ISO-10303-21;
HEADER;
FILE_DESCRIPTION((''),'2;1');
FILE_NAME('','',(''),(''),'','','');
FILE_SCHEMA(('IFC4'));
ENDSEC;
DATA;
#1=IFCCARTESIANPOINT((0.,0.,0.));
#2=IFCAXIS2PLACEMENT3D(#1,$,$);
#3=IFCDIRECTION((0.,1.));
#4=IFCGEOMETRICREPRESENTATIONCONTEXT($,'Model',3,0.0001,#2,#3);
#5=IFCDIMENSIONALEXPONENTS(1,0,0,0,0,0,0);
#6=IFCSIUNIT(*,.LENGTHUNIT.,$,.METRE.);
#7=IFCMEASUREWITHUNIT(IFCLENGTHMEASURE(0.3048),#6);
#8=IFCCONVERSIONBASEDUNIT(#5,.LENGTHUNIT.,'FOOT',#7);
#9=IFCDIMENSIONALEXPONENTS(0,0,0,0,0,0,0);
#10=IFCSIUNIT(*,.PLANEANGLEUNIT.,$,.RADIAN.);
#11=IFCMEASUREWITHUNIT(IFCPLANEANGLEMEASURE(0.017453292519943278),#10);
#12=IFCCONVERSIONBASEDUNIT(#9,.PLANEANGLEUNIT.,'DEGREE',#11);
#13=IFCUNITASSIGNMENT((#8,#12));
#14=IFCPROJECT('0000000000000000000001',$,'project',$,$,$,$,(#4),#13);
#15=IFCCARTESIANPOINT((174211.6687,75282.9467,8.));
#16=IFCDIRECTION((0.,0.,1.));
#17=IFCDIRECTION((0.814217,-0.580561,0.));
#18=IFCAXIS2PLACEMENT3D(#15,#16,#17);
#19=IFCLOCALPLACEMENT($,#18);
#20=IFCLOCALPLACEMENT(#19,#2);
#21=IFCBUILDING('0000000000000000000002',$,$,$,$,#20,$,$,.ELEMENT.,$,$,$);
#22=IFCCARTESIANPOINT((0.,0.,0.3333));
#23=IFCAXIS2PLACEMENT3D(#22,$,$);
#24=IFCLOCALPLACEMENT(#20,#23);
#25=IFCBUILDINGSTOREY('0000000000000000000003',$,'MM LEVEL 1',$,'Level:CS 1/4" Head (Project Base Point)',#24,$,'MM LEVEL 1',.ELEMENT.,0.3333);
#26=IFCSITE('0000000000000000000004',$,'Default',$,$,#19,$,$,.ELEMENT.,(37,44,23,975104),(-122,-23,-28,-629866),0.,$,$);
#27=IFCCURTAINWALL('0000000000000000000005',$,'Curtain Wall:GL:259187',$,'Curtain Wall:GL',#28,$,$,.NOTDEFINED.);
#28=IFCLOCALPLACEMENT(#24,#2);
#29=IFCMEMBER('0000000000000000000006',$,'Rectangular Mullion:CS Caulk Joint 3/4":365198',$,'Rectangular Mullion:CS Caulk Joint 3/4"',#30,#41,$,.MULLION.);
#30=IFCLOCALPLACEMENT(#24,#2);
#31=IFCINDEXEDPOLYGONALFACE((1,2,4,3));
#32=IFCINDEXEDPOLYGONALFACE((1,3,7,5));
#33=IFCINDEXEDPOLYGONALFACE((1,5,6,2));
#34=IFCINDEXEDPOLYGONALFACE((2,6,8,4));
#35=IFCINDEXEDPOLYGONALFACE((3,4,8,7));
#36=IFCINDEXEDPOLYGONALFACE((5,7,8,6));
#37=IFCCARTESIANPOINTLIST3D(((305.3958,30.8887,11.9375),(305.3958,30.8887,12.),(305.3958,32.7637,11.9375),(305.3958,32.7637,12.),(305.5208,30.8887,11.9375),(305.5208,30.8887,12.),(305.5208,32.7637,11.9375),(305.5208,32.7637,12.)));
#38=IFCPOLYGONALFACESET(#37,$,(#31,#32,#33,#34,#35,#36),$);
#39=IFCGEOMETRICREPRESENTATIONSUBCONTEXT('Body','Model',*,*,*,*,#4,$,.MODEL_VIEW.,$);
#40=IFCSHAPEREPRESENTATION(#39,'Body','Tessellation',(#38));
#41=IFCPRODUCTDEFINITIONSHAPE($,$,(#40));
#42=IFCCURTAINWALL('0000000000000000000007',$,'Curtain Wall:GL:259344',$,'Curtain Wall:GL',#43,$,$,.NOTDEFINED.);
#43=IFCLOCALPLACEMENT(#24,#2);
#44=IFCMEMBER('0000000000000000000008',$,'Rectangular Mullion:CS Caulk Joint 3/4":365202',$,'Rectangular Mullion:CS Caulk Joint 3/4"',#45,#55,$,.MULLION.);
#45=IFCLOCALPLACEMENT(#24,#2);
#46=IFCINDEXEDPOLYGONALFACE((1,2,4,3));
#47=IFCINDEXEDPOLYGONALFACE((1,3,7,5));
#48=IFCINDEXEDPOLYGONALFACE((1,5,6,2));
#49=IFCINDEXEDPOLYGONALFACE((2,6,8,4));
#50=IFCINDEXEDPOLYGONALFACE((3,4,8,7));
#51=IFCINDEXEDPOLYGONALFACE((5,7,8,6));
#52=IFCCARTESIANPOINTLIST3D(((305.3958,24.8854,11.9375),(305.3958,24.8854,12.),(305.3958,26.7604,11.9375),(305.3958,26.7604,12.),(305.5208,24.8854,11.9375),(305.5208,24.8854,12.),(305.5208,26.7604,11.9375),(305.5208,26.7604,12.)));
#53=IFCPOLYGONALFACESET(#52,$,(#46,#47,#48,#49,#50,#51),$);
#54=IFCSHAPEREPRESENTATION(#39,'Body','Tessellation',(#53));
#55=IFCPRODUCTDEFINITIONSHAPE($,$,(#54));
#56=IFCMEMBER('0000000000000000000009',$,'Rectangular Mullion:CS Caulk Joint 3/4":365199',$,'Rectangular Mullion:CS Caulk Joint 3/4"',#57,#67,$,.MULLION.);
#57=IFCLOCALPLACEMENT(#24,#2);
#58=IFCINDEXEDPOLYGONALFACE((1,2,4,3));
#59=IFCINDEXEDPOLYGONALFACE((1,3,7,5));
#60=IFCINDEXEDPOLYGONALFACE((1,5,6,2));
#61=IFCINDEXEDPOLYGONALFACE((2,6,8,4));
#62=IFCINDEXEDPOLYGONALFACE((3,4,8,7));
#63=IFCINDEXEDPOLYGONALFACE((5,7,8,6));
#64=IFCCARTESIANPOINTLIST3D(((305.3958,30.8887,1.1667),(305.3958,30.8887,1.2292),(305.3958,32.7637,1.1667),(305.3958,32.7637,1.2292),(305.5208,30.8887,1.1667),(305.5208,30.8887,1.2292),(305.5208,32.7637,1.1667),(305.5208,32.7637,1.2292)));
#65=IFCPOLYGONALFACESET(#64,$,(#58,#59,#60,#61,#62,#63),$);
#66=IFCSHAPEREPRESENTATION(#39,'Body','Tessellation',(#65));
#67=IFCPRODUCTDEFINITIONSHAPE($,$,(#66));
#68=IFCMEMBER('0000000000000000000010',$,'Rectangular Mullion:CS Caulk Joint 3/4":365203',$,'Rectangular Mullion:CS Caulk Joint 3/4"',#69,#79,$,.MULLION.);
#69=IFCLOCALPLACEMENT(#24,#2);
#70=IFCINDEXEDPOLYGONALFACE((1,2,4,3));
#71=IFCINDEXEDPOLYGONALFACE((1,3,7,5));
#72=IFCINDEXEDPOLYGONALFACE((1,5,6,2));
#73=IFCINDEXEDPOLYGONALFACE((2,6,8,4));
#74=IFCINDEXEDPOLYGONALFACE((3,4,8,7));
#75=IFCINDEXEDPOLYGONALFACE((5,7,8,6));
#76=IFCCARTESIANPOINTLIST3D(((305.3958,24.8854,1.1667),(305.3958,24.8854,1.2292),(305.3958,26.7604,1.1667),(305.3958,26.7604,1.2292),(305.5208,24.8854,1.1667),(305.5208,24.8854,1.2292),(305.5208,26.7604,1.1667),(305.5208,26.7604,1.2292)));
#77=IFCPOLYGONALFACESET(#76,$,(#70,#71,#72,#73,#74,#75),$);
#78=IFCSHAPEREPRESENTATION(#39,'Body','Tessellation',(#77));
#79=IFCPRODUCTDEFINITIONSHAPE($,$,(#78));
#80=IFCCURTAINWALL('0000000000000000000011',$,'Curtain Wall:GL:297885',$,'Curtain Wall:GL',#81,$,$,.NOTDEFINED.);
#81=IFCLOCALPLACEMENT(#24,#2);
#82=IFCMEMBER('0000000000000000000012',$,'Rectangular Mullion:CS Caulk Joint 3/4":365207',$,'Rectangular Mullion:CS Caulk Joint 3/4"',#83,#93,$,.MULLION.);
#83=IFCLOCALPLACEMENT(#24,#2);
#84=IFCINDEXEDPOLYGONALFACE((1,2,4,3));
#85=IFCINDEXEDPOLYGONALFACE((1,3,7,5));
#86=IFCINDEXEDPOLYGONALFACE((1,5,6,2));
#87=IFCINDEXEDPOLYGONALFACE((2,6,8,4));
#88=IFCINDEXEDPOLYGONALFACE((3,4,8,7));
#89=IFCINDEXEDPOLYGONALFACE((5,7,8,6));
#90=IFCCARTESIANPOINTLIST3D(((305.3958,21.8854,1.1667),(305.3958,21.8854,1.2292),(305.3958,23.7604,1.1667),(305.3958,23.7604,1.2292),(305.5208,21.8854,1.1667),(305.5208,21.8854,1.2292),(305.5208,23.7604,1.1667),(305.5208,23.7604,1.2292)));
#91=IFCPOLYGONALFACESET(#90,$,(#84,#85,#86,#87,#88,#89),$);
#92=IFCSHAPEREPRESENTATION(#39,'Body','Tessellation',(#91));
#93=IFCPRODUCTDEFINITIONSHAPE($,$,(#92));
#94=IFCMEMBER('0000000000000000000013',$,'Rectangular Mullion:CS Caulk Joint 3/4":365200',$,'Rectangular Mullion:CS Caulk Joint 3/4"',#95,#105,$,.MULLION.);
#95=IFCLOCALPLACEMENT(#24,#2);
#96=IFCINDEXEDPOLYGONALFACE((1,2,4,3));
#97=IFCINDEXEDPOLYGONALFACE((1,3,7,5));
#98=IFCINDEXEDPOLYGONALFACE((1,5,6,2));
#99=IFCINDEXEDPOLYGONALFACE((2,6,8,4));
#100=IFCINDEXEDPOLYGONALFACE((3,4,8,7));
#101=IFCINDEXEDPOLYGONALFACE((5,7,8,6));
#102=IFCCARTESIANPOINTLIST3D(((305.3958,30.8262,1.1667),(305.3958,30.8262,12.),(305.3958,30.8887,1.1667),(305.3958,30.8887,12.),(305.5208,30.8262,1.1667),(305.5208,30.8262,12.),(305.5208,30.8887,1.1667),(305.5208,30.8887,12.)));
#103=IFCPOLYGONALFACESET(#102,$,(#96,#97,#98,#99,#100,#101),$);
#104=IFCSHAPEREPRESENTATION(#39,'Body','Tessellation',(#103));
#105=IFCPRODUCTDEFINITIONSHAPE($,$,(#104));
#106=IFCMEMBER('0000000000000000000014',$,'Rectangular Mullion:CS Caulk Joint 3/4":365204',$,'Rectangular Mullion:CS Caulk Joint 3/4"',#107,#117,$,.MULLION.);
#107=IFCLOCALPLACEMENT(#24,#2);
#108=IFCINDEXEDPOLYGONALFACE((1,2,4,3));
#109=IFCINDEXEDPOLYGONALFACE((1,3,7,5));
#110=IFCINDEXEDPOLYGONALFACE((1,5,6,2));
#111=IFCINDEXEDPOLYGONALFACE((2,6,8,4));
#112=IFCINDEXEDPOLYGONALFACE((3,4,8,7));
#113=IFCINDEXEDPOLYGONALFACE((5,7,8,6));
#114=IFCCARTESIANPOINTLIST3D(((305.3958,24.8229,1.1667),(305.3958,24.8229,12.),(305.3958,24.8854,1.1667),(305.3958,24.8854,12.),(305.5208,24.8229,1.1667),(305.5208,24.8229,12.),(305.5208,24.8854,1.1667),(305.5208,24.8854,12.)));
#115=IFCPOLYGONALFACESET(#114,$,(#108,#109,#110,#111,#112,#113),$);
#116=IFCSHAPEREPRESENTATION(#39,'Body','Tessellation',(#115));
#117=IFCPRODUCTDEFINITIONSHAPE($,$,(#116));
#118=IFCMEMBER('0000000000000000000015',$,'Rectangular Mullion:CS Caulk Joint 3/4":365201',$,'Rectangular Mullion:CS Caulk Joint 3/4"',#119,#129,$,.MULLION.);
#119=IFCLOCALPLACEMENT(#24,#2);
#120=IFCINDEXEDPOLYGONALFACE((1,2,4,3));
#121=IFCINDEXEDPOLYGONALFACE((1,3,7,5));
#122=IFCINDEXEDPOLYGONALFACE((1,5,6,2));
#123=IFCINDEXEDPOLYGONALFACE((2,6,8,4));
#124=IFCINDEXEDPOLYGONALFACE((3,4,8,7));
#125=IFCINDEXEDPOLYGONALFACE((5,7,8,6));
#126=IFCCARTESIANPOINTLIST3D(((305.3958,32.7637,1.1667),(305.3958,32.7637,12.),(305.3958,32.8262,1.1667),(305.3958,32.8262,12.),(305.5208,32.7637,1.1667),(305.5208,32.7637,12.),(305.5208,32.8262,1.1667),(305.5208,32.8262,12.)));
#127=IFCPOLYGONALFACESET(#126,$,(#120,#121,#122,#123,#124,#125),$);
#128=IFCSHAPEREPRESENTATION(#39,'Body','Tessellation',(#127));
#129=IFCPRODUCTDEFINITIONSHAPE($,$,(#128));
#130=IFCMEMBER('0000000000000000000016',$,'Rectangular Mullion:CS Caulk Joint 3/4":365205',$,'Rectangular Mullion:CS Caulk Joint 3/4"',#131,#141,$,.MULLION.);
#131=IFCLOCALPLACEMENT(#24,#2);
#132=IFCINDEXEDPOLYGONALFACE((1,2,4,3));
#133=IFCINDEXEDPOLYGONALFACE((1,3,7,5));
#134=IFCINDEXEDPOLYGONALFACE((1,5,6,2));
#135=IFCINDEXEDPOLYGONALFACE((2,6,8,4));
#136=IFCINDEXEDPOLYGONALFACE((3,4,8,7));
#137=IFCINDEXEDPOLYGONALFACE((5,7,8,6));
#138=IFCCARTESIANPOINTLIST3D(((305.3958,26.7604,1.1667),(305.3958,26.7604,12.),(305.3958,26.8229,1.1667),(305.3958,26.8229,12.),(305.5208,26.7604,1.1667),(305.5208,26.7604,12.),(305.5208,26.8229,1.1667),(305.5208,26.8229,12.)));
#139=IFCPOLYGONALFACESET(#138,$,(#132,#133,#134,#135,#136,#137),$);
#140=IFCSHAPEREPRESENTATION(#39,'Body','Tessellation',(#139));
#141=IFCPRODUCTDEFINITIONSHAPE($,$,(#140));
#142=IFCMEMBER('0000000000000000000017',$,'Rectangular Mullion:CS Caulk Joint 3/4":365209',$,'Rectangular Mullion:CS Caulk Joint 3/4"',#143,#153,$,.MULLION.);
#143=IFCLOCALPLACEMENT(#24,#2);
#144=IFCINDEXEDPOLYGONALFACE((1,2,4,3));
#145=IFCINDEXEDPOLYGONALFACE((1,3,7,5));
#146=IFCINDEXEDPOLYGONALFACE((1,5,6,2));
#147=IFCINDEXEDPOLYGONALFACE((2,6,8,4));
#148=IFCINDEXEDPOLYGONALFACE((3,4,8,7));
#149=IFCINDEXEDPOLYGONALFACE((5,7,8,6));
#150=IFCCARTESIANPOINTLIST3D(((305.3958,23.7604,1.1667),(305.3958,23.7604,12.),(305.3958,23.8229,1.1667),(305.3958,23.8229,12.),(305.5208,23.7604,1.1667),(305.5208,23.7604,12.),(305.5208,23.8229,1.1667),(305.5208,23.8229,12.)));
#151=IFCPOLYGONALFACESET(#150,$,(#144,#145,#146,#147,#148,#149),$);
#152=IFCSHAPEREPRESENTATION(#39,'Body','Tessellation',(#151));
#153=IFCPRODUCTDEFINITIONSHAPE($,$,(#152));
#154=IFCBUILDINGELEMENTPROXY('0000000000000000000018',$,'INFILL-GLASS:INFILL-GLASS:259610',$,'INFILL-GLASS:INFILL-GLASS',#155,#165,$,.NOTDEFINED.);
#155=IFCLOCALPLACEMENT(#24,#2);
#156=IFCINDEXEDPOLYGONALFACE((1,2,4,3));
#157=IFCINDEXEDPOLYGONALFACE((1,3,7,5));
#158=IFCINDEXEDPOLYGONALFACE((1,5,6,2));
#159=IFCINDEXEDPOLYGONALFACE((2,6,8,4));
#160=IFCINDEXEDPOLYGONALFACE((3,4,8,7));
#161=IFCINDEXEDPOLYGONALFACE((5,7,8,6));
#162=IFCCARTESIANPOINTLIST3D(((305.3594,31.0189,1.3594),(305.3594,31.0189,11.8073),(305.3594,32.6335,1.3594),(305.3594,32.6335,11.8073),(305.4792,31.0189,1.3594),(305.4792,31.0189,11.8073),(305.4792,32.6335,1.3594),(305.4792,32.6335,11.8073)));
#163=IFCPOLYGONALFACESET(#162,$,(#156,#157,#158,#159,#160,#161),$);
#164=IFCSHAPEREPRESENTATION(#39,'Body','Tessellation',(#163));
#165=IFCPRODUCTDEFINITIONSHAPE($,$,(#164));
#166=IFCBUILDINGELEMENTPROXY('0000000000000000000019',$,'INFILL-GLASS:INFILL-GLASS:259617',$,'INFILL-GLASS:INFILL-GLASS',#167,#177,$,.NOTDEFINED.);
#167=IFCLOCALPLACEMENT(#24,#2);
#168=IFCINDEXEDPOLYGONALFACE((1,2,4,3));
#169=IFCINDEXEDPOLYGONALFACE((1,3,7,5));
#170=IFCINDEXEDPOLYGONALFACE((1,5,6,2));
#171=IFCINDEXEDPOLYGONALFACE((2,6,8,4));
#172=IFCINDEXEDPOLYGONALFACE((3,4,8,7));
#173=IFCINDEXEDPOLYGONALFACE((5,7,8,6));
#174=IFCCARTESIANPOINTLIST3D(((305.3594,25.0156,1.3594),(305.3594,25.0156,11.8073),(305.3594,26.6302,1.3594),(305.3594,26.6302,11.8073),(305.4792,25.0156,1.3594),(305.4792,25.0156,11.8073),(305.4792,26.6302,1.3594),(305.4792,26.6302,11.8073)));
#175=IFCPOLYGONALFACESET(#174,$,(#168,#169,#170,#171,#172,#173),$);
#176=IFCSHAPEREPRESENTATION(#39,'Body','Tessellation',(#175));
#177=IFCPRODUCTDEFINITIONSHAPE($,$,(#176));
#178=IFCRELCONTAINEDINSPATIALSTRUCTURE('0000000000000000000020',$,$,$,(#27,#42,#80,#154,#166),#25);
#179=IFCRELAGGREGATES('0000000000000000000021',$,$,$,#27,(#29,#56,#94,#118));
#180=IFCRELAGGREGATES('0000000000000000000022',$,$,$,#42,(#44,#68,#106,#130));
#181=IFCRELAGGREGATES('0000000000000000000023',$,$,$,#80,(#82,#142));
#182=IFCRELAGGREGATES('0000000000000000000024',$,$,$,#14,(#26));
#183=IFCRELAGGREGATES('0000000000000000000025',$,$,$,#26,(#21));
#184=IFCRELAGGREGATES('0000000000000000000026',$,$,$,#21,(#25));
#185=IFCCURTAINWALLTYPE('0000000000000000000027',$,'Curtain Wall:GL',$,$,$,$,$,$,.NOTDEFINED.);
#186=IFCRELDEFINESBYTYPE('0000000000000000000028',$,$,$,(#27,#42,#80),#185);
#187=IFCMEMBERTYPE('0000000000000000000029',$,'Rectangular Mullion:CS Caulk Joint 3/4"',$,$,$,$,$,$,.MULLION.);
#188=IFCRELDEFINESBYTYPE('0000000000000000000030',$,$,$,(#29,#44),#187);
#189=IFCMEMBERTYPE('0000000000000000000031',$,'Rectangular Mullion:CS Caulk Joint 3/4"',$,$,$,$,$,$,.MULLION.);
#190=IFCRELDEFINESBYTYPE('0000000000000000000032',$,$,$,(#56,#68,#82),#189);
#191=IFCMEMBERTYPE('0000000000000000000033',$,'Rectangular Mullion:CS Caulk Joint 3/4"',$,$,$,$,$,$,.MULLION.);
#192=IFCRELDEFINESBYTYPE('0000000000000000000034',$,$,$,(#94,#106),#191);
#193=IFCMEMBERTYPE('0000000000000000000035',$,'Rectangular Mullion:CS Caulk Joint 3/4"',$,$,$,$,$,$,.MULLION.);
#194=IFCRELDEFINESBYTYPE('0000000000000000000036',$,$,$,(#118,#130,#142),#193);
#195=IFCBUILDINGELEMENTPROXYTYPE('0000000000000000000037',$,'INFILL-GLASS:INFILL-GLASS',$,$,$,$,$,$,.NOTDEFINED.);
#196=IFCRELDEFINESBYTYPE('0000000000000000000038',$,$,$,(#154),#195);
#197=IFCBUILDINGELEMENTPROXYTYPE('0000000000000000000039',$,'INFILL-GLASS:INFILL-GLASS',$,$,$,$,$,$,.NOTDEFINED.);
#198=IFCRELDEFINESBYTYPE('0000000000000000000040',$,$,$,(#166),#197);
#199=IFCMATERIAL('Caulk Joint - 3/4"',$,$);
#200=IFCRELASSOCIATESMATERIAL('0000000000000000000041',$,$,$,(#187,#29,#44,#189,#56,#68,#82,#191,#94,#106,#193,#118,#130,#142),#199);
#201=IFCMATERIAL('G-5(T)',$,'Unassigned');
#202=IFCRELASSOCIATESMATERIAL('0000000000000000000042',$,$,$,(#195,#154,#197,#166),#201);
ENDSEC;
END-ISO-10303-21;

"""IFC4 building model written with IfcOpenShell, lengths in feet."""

from ifc_helpers import new_model, entity, si_unit, converted_unit, direction, frame, origin, place, context, subcontext, project, spatial, indexed_curve, outline, extrude, source, transform, mapped, material, type_object, type_shapes, element, aggregate, save


model = new_model("IFC4")

# Units and contexts
model_context = context("Model", 3, precision=0.0001, world=origin(), true_north=direction((0.0, 1.0)))
body_context = subcontext(model_context, "Body", "Model", "MODEL_VIEW")
ifc_project = project(units=[converted_unit("LENGTHUNIT", "FOOT", entity("IfcLengthMeasure", 0.3048), si_unit("LENGTHUNIT", "METRE"), dimensions=[1, 0, 0, 0, 0, 0, 0]), converted_unit("PLANEANGLEUNIT", "DEGREE", entity("IfcPlaneAngleMeasure", 0.017453292519943278), si_unit("PLANEANGLEUNIT", "RADIAN"), dimensions=[0, 0, 0, 0, 0, 0, 0])], contexts=[model_context])

# Site, building, storey
site_placement = place(None, frame((174211.6687, 75282.9467, 8.0), z_axis=(0.0, 0.0, 1.0), x_axis=(0.814217, -0.580561, 0.0)))
site = spatial("IfcSite", under=ifc_project, at=site_placement, Name="Default", CompositionType="ELEMENT", RefLatitude=(37, 44, 23, 975104), RefLongitude=(-122, -23, -28, -629866), RefElevation=0.0)
building_placement = place(site_placement, origin())
building = spatial("IfcBuilding", under=site, at=building_placement, CompositionType="ELEMENT")
storey_placement = place(building_placement, frame((0.0, 0.0, 0.3333)))
storey = spatial("IfcBuildingStorey", under=building, at=storey_placement, Name="MM LEVEL 1", ObjectType="Level:CS 1/4\" Head (Project Base Point)", LongName="MM LEVEL 1", CompositionType="ELEMENT", Elevation=0.3333)

# Curtain walls, members
curtain_wall_type_1 = type_object("IfcCurtainWallType", Name="Curtain Wall:GL", PredefinedType="NOTDEFINED")
curtain_wall_1_placement = place(storey_placement, frame((0.0, 0.0, -0.3333)))
curtain_wall_1 = element("IfcCurtainWall", 1, at=curtain_wall_1_placement, inside=storey, type_object=curtain_wall_type_1, Name="Curtain Wall:GL:259187", ObjectType="Curtain Wall:GL", PredefinedType="NOTDEFINED")
ifc_material_1 = material(Name="Caulk Joint - 3/4\"")
member_type_1 = type_object("IfcMemberType", Name="Rectangular Mullion:CS Caulk Joint 3/4\"", PredefinedType="MULLION", material=ifc_material_1)
shared_shape_1 = source(origin(), body_context, "Body", "SweptSolid", [
    extrude(outline(indexed_curve([(-0.0625, -0.0312), (0.0625, -0.0312), (0.0625, 0.0312), (-0.0625, 0.0312), (-0.0625, -0.0312)], self_intersect=False)), frame((-0.0312, 0.0625, -1.875), z_axis=(0.0, 0.0, 1.0), x_axis=(0.0, -1.0, 0.0)), (0.0, 0.0, 1.0), 1.875),
])
type_shapes(member_type_1, [shared_shape_1])
member_1_placement = place(curtain_wall_1_placement, frame((305.5208, 30.8887, 12.3333), z_axis=(0.0, -1.0, 0.0), x_axis=(0.0, 0.0, 1.0)))
member_1 = element("IfcMember", 2, at=member_1_placement, type_object=member_type_1, material=ifc_material_1, Name="Rectangular Mullion:CS Caulk Joint 3/4\":365198", ObjectType="Rectangular Mullion:CS Caulk Joint 3/4\"", PredefinedType="MULLION", context=body_context, shape_type="MappedRepresentation", body=[
    mapped(shared_shape_1, transform((0.0, 0.0, 0.0), scale=1.0)),
])
curtain_wall_2_placement = place(storey_placement, frame((0.0, 0.0, -0.3333)))
curtain_wall_2 = element("IfcCurtainWall", 3, at=curtain_wall_2_placement, inside=storey, type_object=curtain_wall_type_1, Name="Curtain Wall:GL:259344", ObjectType="Curtain Wall:GL", PredefinedType="NOTDEFINED")
member_2_placement = place(curtain_wall_2_placement, frame((305.5208, 24.8854, 12.3333), z_axis=(0.0, -1.0, 0.0), x_axis=(0.0, 0.0, 1.0)))
member_2 = element("IfcMember", 4, at=member_2_placement, type_object=member_type_1, material=ifc_material_1, Name="Rectangular Mullion:CS Caulk Joint 3/4\":365202", ObjectType="Rectangular Mullion:CS Caulk Joint 3/4\"", PredefinedType="MULLION", context=body_context, shape_type="MappedRepresentation", body=[
    mapped(shared_shape_1, transform((0.0, 0.0, 0.0), scale=1.0)),
])

# Members
member_type_2 = type_object("IfcMemberType", Name="Rectangular Mullion:CS Caulk Joint 3/4\"", PredefinedType="MULLION", material=ifc_material_1)
shared_shape_2 = source(origin(), body_context, "Body", "SweptSolid", [
    extrude(outline(indexed_curve([(-0.0312, -0.0625), (0.0312, -0.0625), (0.0312, 0.0625), (-0.0312, 0.0625), (-0.0312, -0.0625)], self_intersect=False)), frame((-0.0312, 0.0625, -1.875), z_axis=(0.0, 0.0, 1.0), x_axis=(-1.0, 0.0, 0.0)), (0.0, 0.0, 1.0), 1.875),
])
type_shapes(member_type_2, [shared_shape_2])
member_3_placement = place(curtain_wall_1_placement, frame((305.5208, 32.7637, 1.5), z_axis=(0.0, 1.0, 0.0), x_axis=(0.0, 0.0, -1.0)))
member_3 = element("IfcMember", 5, at=member_3_placement, type_object=member_type_2, material=ifc_material_1, Name="Rectangular Mullion:CS Caulk Joint 3/4\":365199", ObjectType="Rectangular Mullion:CS Caulk Joint 3/4\"", PredefinedType="MULLION", context=body_context, shape_type="MappedRepresentation", body=[
    mapped(shared_shape_2, transform((0.0, 0.0, 0.0), scale=1.0)),
])
member_4_placement = place(curtain_wall_2_placement, frame((305.5208, 26.7604, 1.5), z_axis=(0.0, 1.0, 0.0), x_axis=(0.0, 0.0, -1.0)))
member_4 = element("IfcMember", 6, at=member_4_placement, type_object=member_type_2, material=ifc_material_1, Name="Rectangular Mullion:CS Caulk Joint 3/4\":365203", ObjectType="Rectangular Mullion:CS Caulk Joint 3/4\"", PredefinedType="MULLION", context=body_context, shape_type="MappedRepresentation", body=[
    mapped(shared_shape_2, transform((0.0, 0.0, 0.0), scale=1.0)),
])

# Curtain wall, member
curtain_wall_3_placement = place(storey_placement, frame((0.0, 0.0, -0.3333)))
curtain_wall_3 = element("IfcCurtainWall", 7, at=curtain_wall_3_placement, inside=storey, type_object=curtain_wall_type_1, Name="Curtain Wall:GL:297885", ObjectType="Curtain Wall:GL", PredefinedType="NOTDEFINED")
member_5_placement = place(curtain_wall_3_placement, frame((305.5208, 23.7604, 1.5), z_axis=(0.0, 1.0, 0.0), x_axis=(0.0, 0.0, -1.0)))
member_5 = element("IfcMember", 8, at=member_5_placement, type_object=member_type_2, material=ifc_material_1, Name="Rectangular Mullion:CS Caulk Joint 3/4\":365207", ObjectType="Rectangular Mullion:CS Caulk Joint 3/4\"", PredefinedType="MULLION", context=body_context, shape_type="MappedRepresentation", body=[
    mapped(shared_shape_2, transform((0.0, 0.0, 0.0), scale=1.0)),
])

# Members
member_type_3 = type_object("IfcMemberType", Name="Rectangular Mullion:CS Caulk Joint 3/4\"", PredefinedType="MULLION", material=ifc_material_1)
shared_shape_3 = source(origin(), body_context, "Body", "SweptSolid", [
    extrude(outline(indexed_curve([(-0.0625, -0.0312), (0.0625, -0.0312), (0.0625, 0.0312), (-0.0625, 0.0312), (-0.0625, -0.0312)], self_intersect=False)), frame((-0.0312, 0.0625, -10.8333), z_axis=(0.0, 0.0, 1.0), x_axis=(0.0, -1.0, 0.0)), (0.0, 0.0, 1.0), 10.8333),
])
type_shapes(member_type_3, [shared_shape_3])
member_6_placement = place(curtain_wall_1_placement, frame((305.5208, 30.8262, 1.5), z_axis=(0.0, 0.0, -1.0), x_axis=(0.0, -1.0, 0.0)))
member_6 = element("IfcMember", 9, at=member_6_placement, type_object=member_type_3, material=ifc_material_1, Name="Rectangular Mullion:CS Caulk Joint 3/4\":365200", ObjectType="Rectangular Mullion:CS Caulk Joint 3/4\"", PredefinedType="MULLION", context=body_context, shape_type="MappedRepresentation", body=[
    mapped(shared_shape_3, transform((0.0, 0.0, 0.0), scale=1.0)),
])
member_7_placement = place(curtain_wall_2_placement, frame((305.5208, 24.8229, 1.5), z_axis=(0.0, 0.0, -1.0), x_axis=(0.0, -1.0, 0.0)))
member_7 = element("IfcMember", 10, at=member_7_placement, type_object=member_type_3, material=ifc_material_1, Name="Rectangular Mullion:CS Caulk Joint 3/4\":365204", ObjectType="Rectangular Mullion:CS Caulk Joint 3/4\"", PredefinedType="MULLION", context=body_context, shape_type="MappedRepresentation", body=[
    mapped(shared_shape_3, transform((0.0, 0.0, 0.0), scale=1.0)),
])
member_type_4 = type_object("IfcMemberType", Name="Rectangular Mullion:CS Caulk Joint 3/4\"", PredefinedType="MULLION", material=ifc_material_1)
shared_shape_4 = source(origin(), body_context, "Body", "SweptSolid", [
    extrude(outline(indexed_curve([(-0.0312, -0.0625), (0.0312, -0.0625), (0.0312, 0.0625), (-0.0312, 0.0625), (-0.0312, -0.0625)], self_intersect=False)), frame((-0.0312, 0.0625, -10.8333), z_axis=(0.0, 0.0, 1.0), x_axis=(-1.0, 0.0, 0.0)), (0.0, 0.0, 1.0), 10.8333),
])
type_shapes(member_type_4, [shared_shape_4])
member_8_placement = place(curtain_wall_1_placement, frame((305.5208, 32.8262, 12.3333), z_axis=(0.0, 0.0, 1.0), x_axis=(0.0, 1.0, 0.0)))
member_8 = element("IfcMember", 11, at=member_8_placement, type_object=member_type_4, material=ifc_material_1, Name="Rectangular Mullion:CS Caulk Joint 3/4\":365201", ObjectType="Rectangular Mullion:CS Caulk Joint 3/4\"", PredefinedType="MULLION", context=body_context, shape_type="MappedRepresentation", body=[
    mapped(shared_shape_4, transform((0.0, 0.0, 0.0), scale=1.0)),
])
aggregate(curtain_wall_1, [member_1, member_3, member_6, member_8])
member_9_placement = place(curtain_wall_2_placement, frame((305.5208, 26.8229, 12.3333), z_axis=(0.0, 0.0, 1.0), x_axis=(0.0, 1.0, 0.0)))
member_9 = element("IfcMember", 12, at=member_9_placement, type_object=member_type_4, material=ifc_material_1, Name="Rectangular Mullion:CS Caulk Joint 3/4\":365205", ObjectType="Rectangular Mullion:CS Caulk Joint 3/4\"", PredefinedType="MULLION", context=body_context, shape_type="MappedRepresentation", body=[
    mapped(shared_shape_4, transform((0.0, 0.0, 0.0), scale=1.0)),
])
aggregate(curtain_wall_2, [member_2, member_4, member_7, member_9])
member_10_placement = place(curtain_wall_3_placement, frame((305.5208, 23.8229, 12.3333), z_axis=(0.0, 0.0, 1.0), x_axis=(0.0, 1.0, 0.0)))
member_10 = element("IfcMember", 13, at=member_10_placement, type_object=member_type_4, material=ifc_material_1, Name="Rectangular Mullion:CS Caulk Joint 3/4\":365209", ObjectType="Rectangular Mullion:CS Caulk Joint 3/4\"", PredefinedType="MULLION", context=body_context, shape_type="MappedRepresentation", body=[
    mapped(shared_shape_4, transform((0.0, 0.0, 0.0), scale=1.0)),
])
aggregate(curtain_wall_3, [member_5, member_10])

# Building element proxies
ifc_material_2 = material(Name="G-5(T)", Category="Unassigned")
building_element_proxy_type_1 = type_object("IfcBuildingElementProxyType", Name="INFILL-GLASS:INFILL-GLASS", PredefinedType="NOTDEFINED", material=ifc_material_2)
shared_shape_5 = source(origin(), body_context, "Body", "SweptSolid", [
    extrude(outline(indexed_curve([(-0.0599, -0.8073), (0.0599, -0.8073), (0.0599, 0.8073), (-0.0599, 0.8073), (-0.0599, -0.8073)], self_intersect=False)), frame((0.0, 0.1016, 0.1302), z_axis=(0.0, 0.0, 1.0), x_axis=(0.0, 1.0, 0.0)), (0.0, 0.0, 1.0), 10.4479),
])
type_shapes(building_element_proxy_type_1, [shared_shape_5])
proxy_1_placement = place(storey_placement, frame((305.5208, 31.8262, 1.2292), z_axis=(0.0, 0.0, 1.0), x_axis=(0.0, 1.0, 0.0)))
element("IfcBuildingElementProxy", 14, at=proxy_1_placement, inside=storey, type_object=building_element_proxy_type_1, material=ifc_material_2, Name="INFILL-GLASS:INFILL-GLASS:259610", ObjectType="INFILL-GLASS:INFILL-GLASS", PredefinedType="NOTDEFINED", context=body_context, shape_type="MappedRepresentation", body=[
    mapped(shared_shape_5, transform((0.0, 0.0, 0.0), scale=1.0)),
])
building_element_proxy_type_2 = type_object("IfcBuildingElementProxyType", Name="INFILL-GLASS:INFILL-GLASS", PredefinedType="NOTDEFINED", material=ifc_material_2)
shared_shape_6 = source(origin(), body_context, "Body", "SweptSolid", [
    extrude(outline(indexed_curve([(-0.0599, -0.8073), (0.0599, -0.8073), (0.0599, 0.8073), (-0.0599, 0.8073), (-0.0599, -0.8073)], self_intersect=False)), frame((0.0, 0.1016, 0.1302), z_axis=(0.0, 0.0, 1.0), x_axis=(0.0, 1.0, 0.0)), (0.0, 0.0, 1.0), 10.4479),
])
type_shapes(building_element_proxy_type_2, [shared_shape_6])
for number, where, z_axis, x_axis, name in (
    (15, (305.5208, 25.8229, 1.2292), (0.0, 0.0, 1.0), (0.0, 1.0, 0.0), "INFILL-GLASS:INFILL-GLASS:259617"),
):
    element("IfcBuildingElementProxy", number, at=place(storey_placement, frame(where, z_axis=z_axis, x_axis=x_axis)), inside=storey, type_object=building_element_proxy_type_2, material=ifc_material_2, Name=name, ObjectType="INFILL-GLASS:INFILL-GLASS", PredefinedType="NOTDEFINED", context=body_context, shape_type="MappedRepresentation", body=[
        mapped(shared_shape_6, transform((0.0, 0.0, 0.0), scale=1.0)),
    ])

save(model, "model.ifc")
